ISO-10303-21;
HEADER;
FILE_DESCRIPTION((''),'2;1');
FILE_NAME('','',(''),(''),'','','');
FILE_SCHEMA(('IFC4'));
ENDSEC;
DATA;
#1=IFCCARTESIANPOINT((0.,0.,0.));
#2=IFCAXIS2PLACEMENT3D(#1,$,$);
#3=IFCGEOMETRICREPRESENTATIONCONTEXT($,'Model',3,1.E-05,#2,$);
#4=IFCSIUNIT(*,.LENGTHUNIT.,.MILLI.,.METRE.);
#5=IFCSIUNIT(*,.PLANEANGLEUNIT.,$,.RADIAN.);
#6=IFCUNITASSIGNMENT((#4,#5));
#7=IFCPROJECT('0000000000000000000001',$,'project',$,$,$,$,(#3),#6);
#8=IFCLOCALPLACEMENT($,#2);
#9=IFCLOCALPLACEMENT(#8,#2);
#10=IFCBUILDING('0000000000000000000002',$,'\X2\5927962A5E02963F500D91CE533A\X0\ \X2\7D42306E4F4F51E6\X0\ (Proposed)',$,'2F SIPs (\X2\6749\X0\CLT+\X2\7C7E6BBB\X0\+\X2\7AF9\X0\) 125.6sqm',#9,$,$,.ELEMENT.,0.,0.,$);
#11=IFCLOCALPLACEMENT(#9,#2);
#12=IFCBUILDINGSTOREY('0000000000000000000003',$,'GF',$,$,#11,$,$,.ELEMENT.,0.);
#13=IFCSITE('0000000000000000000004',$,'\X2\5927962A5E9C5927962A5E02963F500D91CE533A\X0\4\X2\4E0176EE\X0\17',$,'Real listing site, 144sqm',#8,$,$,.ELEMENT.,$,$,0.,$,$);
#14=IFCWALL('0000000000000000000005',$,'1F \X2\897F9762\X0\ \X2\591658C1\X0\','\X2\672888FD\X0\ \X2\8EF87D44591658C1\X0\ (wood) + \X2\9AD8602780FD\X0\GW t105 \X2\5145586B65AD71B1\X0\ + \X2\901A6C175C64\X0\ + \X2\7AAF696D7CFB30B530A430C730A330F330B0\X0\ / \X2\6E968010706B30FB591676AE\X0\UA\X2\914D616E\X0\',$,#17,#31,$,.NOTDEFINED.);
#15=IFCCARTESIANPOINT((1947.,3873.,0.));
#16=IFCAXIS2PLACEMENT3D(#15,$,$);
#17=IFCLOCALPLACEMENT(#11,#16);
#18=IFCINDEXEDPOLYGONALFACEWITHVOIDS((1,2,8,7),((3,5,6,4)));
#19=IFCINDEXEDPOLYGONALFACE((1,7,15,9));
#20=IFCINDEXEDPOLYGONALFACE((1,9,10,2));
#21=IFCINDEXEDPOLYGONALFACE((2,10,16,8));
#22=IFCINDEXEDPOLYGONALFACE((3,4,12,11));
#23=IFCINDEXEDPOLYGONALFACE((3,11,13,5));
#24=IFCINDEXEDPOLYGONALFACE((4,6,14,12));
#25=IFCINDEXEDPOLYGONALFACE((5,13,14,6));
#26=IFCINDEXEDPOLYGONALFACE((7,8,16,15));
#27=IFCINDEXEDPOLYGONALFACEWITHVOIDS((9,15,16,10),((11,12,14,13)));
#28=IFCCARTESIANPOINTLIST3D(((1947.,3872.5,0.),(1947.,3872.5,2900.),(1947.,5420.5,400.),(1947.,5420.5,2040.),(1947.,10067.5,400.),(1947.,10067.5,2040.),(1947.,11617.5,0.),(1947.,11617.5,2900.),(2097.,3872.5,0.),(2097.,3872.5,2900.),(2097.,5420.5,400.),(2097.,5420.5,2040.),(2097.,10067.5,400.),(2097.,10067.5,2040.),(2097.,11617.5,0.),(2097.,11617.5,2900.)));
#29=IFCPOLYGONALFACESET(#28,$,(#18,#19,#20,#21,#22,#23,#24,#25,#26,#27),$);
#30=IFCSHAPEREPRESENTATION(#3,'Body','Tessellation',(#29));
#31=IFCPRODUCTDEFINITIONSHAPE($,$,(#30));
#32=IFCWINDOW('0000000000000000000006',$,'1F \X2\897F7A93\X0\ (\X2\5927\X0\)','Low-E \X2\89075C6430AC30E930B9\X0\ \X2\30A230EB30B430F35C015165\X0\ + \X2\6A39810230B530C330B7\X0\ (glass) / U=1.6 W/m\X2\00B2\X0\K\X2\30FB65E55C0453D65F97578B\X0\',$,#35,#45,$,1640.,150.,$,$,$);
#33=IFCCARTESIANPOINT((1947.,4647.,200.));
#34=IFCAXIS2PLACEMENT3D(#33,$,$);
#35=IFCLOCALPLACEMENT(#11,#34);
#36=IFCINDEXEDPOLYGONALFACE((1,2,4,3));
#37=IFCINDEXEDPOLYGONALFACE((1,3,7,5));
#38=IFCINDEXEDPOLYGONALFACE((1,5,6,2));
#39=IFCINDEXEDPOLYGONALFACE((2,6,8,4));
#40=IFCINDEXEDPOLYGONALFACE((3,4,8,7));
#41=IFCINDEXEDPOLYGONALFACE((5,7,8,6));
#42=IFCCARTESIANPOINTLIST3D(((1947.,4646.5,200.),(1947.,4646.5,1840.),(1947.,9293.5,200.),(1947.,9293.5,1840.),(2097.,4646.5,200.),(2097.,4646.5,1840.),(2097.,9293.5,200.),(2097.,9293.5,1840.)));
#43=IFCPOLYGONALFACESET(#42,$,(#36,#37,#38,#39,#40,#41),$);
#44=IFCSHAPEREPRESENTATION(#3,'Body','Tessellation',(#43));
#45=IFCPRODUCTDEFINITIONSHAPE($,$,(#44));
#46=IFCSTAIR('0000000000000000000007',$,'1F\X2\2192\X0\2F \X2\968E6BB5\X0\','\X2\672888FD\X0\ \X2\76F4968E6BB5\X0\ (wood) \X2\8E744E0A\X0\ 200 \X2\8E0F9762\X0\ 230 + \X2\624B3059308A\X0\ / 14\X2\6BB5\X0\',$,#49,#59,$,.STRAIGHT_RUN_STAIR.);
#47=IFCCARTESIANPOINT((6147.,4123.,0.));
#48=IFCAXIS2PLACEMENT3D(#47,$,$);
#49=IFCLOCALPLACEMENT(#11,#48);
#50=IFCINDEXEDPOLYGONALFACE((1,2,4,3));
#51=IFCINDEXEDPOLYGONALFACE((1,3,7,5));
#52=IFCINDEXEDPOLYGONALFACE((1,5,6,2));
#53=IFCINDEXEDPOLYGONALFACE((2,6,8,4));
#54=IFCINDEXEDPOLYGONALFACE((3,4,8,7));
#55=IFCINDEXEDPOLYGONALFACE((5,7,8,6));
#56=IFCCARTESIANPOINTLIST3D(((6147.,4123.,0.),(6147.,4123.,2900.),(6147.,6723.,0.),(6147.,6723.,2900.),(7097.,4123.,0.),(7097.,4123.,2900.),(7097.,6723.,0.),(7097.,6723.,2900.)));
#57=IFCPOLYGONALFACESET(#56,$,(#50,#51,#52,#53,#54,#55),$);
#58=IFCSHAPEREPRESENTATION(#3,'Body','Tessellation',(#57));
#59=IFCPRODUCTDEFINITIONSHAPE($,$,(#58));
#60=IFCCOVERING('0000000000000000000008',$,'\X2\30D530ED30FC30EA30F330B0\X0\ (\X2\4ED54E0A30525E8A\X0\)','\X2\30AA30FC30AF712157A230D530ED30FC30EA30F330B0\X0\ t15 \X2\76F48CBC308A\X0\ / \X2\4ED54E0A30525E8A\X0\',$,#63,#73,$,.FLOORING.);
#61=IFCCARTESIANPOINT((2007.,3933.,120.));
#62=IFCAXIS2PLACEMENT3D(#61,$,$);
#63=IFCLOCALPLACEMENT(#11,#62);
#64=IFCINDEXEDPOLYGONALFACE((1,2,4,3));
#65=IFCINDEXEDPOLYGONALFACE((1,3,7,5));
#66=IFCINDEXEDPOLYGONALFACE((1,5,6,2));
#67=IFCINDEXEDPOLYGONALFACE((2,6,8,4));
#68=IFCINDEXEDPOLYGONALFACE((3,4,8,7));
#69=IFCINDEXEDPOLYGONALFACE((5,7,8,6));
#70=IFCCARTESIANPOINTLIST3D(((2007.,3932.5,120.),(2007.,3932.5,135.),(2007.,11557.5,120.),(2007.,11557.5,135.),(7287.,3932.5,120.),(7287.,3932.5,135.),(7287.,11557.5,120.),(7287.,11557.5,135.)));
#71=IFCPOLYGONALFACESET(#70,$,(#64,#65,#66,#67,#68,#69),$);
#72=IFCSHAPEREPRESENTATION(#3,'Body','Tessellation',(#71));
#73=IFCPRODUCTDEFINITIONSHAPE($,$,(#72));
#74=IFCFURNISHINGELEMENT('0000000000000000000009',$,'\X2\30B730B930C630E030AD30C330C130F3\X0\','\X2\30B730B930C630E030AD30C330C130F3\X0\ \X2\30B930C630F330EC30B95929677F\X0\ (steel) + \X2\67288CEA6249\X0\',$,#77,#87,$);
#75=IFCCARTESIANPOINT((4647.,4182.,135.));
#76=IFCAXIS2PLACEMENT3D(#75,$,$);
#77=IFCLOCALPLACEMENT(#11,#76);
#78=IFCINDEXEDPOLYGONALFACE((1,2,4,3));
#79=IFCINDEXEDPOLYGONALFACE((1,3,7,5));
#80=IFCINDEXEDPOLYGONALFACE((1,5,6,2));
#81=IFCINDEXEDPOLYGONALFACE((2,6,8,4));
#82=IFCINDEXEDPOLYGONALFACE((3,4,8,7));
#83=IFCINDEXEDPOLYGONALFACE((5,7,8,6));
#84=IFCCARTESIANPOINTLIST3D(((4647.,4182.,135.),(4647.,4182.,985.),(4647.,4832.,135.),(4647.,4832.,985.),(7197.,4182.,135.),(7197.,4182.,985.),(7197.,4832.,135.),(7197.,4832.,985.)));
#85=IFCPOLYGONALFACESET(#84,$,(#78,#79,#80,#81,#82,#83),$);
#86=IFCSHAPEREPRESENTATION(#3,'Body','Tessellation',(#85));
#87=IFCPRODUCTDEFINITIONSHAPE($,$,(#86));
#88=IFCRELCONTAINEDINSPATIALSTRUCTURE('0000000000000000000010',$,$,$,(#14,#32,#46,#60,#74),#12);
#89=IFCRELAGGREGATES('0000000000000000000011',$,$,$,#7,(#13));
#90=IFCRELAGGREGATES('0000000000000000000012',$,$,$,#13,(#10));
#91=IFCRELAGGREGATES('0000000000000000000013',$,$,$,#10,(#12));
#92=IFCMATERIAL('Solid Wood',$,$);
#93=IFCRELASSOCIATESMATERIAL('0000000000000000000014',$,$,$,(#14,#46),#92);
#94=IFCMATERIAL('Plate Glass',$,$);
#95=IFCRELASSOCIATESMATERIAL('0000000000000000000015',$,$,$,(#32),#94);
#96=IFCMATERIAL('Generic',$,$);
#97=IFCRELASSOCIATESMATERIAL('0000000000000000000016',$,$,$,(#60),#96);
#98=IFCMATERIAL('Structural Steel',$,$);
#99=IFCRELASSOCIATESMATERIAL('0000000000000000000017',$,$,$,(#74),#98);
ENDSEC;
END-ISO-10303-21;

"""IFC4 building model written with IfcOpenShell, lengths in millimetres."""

from ifc_helpers import new_model, si_unit, frame, frame_2d, origin, place, context, project, spatial, rectangle, extrude, material, element, fill, save


model = new_model("IFC4")

# Units and contexts
model_context = context("Model", 3, precision=1e-05, world=origin())
ifc_project = project(units=[si_unit("LENGTHUNIT", "METRE", prefix="MILLI"), si_unit("PLANEANGLEUNIT", "RADIAN")], contexts=[model_context])

# Site, building, storey
site_placement = place(None, origin())
site = spatial("IfcSite", under=ifc_project, at=site_placement, Name="大阪府大阪市阿倍野区4丁目17", ObjectType="Real listing site, 144sqm", CompositionType="ELEMENT", RefElevation=0.0)
building_placement = place(site_placement, origin())
building = spatial("IfcBuilding", under=site, at=building_placement, Name="大阪市阿倍野区 終の住処 (Proposed)", ObjectType="2F SIPs (杉CLT+籾殻+竹) 125.6sqm", CompositionType="ELEMENT", ElevationOfRefHeight=0.0, ElevationOfTerrain=0.0)
storey_placement = place(building_placement, origin())
storey = spatial("IfcBuildingStorey", under=building, at=storey_placement, Name="GF", CompositionType="ELEMENT", Elevation=0.0)

# Shared definitions
ifc_material_1 = material(Name="Solid Wood")
ifc_material_2 = material(Name="Generic")

# Shared definitions
ifc_material_3 = material(Name="Plate Glass")

# Wall, opening, window
wall_1_placement = place(storey_placement, frame((1947.0, 3873.0, 0.0)))
wall_1 = element("IfcWall", 1, at=wall_1_placement, inside=storey, material=ifc_material_1, Name="1F 西面 外壁", Description="木製 軸組外壁 (wood) + 高性能GW t105 充填断熱 + 通気層 + 窯業系サイディング / 準耐火・外皮UA配慮", PredefinedType="NOTDEFINED", context=model_context, shape_type="SweptSolid", body=[
    extrude(rectangle(XDim=150.0, YDim=7745.0, at=frame_2d((75.0, 3872.0))), frame((1947.0, 3873.0, 0.0)), (0.0, 0.0, 1.0), 2900.0),
])
opening_1_placement = place(storey_placement, frame((1947.0, 4647.0, 200.0)))
opening_1 = element("IfcOpeningElement", 2, at=opening_1_placement, cuts=wall_1, PredefinedType="NOTDEFINED", context=model_context, shape_type="SweptSolid", body=[
    extrude(rectangle(XDim=150.0, YDim=4647.0, at=frame_2d((75.0, 2323.0))), frame((1947.0, 4647.0, 200.0)), (0.0, 0.0, 1.0), 1640.0),
])
window_1_placement = place(storey_placement, frame((1947.0, 4647.0, 200.0)))
window_1 = element("IfcWindow", 3, at=window_1_placement, inside=storey, material=ifc_material_3, Name="1F 西窓 (大)", Description="Low-E 複層ガラス アルゴン封入 + 樹脂サッシ (glass) / U=1.6 W/m²K・日射取得型", OverallHeight=1640.0, OverallWidth=150.0, context=model_context, shape_type="SweptSolid", body=[
    extrude(rectangle(XDim=150.0, YDim=4647.0, at=frame_2d((75.0, 2323.0))), frame((1947.0, 4647.0, 200.0)), (0.0, 0.0, 1.0), 1640.0),
])
fill(opening_1, window_1)

# Stair
stair_placement = place(storey_placement, frame((6147.0, 4123.0, 0.0)))
element("IfcStair", 4, at=stair_placement, inside=storey, material=ifc_material_1, Name="1F→2F 階段", Description="木製 直階段 (wood) 蹴上 200 踏面 230 + 手すり / 14段", PredefinedType="STRAIGHT_RUN_STAIR", context=model_context, shape_type="SweptSolid", body=[
    extrude(rectangle(XDim=950.0, YDim=2600.0, at=frame_2d((475.0, 1300.0))), frame((6147.0, 4123.0, 0.0)), (0.0, 0.0, 1.0), 2900.0),
])

# Covering
covering_placement = place(storey_placement, frame((2007.0, 3933.0, 120.0)))
element("IfcCovering", 5, at=covering_placement, inside=storey, material=ifc_material_2, Name="フローリング (仕上げ床)", Description="オーク無垢フローリング t15 直貼り / 仕上げ床", PredefinedType="FLOORING", context=model_context, shape_type="SweptSolid", body=[
    extrude(rectangle(XDim=5280.0, YDim=7625.0, at=frame_2d((2640.0, 3812.0))), frame((2007.0, 3933.0, 120.0)), (0.0, 0.0, 1.0), 15.0),
])

# Furnishing element
ifc_material_4 = material(Name="Structural Steel")
furnishing_placement = place(storey_placement, frame((4647.0, 4182.0, 135.0)))
element("IfcFurnishingElement", 6, at=furnishing_placement, inside=storey, material=ifc_material_4, Name="システムキッチン", Description="システムキッチン ステンレス天板 (steel) + 木質扉", context=model_context, shape_type="SweptSolid", body=[
    extrude(rectangle(XDim=2550.0, YDim=650.0, at=frame_2d((1275.0, 325.0))), frame((4647.0, 4182.0, 135.0)), (0.0, 0.0, 1.0), 850.0),
])

save(model, "model.ifc")
